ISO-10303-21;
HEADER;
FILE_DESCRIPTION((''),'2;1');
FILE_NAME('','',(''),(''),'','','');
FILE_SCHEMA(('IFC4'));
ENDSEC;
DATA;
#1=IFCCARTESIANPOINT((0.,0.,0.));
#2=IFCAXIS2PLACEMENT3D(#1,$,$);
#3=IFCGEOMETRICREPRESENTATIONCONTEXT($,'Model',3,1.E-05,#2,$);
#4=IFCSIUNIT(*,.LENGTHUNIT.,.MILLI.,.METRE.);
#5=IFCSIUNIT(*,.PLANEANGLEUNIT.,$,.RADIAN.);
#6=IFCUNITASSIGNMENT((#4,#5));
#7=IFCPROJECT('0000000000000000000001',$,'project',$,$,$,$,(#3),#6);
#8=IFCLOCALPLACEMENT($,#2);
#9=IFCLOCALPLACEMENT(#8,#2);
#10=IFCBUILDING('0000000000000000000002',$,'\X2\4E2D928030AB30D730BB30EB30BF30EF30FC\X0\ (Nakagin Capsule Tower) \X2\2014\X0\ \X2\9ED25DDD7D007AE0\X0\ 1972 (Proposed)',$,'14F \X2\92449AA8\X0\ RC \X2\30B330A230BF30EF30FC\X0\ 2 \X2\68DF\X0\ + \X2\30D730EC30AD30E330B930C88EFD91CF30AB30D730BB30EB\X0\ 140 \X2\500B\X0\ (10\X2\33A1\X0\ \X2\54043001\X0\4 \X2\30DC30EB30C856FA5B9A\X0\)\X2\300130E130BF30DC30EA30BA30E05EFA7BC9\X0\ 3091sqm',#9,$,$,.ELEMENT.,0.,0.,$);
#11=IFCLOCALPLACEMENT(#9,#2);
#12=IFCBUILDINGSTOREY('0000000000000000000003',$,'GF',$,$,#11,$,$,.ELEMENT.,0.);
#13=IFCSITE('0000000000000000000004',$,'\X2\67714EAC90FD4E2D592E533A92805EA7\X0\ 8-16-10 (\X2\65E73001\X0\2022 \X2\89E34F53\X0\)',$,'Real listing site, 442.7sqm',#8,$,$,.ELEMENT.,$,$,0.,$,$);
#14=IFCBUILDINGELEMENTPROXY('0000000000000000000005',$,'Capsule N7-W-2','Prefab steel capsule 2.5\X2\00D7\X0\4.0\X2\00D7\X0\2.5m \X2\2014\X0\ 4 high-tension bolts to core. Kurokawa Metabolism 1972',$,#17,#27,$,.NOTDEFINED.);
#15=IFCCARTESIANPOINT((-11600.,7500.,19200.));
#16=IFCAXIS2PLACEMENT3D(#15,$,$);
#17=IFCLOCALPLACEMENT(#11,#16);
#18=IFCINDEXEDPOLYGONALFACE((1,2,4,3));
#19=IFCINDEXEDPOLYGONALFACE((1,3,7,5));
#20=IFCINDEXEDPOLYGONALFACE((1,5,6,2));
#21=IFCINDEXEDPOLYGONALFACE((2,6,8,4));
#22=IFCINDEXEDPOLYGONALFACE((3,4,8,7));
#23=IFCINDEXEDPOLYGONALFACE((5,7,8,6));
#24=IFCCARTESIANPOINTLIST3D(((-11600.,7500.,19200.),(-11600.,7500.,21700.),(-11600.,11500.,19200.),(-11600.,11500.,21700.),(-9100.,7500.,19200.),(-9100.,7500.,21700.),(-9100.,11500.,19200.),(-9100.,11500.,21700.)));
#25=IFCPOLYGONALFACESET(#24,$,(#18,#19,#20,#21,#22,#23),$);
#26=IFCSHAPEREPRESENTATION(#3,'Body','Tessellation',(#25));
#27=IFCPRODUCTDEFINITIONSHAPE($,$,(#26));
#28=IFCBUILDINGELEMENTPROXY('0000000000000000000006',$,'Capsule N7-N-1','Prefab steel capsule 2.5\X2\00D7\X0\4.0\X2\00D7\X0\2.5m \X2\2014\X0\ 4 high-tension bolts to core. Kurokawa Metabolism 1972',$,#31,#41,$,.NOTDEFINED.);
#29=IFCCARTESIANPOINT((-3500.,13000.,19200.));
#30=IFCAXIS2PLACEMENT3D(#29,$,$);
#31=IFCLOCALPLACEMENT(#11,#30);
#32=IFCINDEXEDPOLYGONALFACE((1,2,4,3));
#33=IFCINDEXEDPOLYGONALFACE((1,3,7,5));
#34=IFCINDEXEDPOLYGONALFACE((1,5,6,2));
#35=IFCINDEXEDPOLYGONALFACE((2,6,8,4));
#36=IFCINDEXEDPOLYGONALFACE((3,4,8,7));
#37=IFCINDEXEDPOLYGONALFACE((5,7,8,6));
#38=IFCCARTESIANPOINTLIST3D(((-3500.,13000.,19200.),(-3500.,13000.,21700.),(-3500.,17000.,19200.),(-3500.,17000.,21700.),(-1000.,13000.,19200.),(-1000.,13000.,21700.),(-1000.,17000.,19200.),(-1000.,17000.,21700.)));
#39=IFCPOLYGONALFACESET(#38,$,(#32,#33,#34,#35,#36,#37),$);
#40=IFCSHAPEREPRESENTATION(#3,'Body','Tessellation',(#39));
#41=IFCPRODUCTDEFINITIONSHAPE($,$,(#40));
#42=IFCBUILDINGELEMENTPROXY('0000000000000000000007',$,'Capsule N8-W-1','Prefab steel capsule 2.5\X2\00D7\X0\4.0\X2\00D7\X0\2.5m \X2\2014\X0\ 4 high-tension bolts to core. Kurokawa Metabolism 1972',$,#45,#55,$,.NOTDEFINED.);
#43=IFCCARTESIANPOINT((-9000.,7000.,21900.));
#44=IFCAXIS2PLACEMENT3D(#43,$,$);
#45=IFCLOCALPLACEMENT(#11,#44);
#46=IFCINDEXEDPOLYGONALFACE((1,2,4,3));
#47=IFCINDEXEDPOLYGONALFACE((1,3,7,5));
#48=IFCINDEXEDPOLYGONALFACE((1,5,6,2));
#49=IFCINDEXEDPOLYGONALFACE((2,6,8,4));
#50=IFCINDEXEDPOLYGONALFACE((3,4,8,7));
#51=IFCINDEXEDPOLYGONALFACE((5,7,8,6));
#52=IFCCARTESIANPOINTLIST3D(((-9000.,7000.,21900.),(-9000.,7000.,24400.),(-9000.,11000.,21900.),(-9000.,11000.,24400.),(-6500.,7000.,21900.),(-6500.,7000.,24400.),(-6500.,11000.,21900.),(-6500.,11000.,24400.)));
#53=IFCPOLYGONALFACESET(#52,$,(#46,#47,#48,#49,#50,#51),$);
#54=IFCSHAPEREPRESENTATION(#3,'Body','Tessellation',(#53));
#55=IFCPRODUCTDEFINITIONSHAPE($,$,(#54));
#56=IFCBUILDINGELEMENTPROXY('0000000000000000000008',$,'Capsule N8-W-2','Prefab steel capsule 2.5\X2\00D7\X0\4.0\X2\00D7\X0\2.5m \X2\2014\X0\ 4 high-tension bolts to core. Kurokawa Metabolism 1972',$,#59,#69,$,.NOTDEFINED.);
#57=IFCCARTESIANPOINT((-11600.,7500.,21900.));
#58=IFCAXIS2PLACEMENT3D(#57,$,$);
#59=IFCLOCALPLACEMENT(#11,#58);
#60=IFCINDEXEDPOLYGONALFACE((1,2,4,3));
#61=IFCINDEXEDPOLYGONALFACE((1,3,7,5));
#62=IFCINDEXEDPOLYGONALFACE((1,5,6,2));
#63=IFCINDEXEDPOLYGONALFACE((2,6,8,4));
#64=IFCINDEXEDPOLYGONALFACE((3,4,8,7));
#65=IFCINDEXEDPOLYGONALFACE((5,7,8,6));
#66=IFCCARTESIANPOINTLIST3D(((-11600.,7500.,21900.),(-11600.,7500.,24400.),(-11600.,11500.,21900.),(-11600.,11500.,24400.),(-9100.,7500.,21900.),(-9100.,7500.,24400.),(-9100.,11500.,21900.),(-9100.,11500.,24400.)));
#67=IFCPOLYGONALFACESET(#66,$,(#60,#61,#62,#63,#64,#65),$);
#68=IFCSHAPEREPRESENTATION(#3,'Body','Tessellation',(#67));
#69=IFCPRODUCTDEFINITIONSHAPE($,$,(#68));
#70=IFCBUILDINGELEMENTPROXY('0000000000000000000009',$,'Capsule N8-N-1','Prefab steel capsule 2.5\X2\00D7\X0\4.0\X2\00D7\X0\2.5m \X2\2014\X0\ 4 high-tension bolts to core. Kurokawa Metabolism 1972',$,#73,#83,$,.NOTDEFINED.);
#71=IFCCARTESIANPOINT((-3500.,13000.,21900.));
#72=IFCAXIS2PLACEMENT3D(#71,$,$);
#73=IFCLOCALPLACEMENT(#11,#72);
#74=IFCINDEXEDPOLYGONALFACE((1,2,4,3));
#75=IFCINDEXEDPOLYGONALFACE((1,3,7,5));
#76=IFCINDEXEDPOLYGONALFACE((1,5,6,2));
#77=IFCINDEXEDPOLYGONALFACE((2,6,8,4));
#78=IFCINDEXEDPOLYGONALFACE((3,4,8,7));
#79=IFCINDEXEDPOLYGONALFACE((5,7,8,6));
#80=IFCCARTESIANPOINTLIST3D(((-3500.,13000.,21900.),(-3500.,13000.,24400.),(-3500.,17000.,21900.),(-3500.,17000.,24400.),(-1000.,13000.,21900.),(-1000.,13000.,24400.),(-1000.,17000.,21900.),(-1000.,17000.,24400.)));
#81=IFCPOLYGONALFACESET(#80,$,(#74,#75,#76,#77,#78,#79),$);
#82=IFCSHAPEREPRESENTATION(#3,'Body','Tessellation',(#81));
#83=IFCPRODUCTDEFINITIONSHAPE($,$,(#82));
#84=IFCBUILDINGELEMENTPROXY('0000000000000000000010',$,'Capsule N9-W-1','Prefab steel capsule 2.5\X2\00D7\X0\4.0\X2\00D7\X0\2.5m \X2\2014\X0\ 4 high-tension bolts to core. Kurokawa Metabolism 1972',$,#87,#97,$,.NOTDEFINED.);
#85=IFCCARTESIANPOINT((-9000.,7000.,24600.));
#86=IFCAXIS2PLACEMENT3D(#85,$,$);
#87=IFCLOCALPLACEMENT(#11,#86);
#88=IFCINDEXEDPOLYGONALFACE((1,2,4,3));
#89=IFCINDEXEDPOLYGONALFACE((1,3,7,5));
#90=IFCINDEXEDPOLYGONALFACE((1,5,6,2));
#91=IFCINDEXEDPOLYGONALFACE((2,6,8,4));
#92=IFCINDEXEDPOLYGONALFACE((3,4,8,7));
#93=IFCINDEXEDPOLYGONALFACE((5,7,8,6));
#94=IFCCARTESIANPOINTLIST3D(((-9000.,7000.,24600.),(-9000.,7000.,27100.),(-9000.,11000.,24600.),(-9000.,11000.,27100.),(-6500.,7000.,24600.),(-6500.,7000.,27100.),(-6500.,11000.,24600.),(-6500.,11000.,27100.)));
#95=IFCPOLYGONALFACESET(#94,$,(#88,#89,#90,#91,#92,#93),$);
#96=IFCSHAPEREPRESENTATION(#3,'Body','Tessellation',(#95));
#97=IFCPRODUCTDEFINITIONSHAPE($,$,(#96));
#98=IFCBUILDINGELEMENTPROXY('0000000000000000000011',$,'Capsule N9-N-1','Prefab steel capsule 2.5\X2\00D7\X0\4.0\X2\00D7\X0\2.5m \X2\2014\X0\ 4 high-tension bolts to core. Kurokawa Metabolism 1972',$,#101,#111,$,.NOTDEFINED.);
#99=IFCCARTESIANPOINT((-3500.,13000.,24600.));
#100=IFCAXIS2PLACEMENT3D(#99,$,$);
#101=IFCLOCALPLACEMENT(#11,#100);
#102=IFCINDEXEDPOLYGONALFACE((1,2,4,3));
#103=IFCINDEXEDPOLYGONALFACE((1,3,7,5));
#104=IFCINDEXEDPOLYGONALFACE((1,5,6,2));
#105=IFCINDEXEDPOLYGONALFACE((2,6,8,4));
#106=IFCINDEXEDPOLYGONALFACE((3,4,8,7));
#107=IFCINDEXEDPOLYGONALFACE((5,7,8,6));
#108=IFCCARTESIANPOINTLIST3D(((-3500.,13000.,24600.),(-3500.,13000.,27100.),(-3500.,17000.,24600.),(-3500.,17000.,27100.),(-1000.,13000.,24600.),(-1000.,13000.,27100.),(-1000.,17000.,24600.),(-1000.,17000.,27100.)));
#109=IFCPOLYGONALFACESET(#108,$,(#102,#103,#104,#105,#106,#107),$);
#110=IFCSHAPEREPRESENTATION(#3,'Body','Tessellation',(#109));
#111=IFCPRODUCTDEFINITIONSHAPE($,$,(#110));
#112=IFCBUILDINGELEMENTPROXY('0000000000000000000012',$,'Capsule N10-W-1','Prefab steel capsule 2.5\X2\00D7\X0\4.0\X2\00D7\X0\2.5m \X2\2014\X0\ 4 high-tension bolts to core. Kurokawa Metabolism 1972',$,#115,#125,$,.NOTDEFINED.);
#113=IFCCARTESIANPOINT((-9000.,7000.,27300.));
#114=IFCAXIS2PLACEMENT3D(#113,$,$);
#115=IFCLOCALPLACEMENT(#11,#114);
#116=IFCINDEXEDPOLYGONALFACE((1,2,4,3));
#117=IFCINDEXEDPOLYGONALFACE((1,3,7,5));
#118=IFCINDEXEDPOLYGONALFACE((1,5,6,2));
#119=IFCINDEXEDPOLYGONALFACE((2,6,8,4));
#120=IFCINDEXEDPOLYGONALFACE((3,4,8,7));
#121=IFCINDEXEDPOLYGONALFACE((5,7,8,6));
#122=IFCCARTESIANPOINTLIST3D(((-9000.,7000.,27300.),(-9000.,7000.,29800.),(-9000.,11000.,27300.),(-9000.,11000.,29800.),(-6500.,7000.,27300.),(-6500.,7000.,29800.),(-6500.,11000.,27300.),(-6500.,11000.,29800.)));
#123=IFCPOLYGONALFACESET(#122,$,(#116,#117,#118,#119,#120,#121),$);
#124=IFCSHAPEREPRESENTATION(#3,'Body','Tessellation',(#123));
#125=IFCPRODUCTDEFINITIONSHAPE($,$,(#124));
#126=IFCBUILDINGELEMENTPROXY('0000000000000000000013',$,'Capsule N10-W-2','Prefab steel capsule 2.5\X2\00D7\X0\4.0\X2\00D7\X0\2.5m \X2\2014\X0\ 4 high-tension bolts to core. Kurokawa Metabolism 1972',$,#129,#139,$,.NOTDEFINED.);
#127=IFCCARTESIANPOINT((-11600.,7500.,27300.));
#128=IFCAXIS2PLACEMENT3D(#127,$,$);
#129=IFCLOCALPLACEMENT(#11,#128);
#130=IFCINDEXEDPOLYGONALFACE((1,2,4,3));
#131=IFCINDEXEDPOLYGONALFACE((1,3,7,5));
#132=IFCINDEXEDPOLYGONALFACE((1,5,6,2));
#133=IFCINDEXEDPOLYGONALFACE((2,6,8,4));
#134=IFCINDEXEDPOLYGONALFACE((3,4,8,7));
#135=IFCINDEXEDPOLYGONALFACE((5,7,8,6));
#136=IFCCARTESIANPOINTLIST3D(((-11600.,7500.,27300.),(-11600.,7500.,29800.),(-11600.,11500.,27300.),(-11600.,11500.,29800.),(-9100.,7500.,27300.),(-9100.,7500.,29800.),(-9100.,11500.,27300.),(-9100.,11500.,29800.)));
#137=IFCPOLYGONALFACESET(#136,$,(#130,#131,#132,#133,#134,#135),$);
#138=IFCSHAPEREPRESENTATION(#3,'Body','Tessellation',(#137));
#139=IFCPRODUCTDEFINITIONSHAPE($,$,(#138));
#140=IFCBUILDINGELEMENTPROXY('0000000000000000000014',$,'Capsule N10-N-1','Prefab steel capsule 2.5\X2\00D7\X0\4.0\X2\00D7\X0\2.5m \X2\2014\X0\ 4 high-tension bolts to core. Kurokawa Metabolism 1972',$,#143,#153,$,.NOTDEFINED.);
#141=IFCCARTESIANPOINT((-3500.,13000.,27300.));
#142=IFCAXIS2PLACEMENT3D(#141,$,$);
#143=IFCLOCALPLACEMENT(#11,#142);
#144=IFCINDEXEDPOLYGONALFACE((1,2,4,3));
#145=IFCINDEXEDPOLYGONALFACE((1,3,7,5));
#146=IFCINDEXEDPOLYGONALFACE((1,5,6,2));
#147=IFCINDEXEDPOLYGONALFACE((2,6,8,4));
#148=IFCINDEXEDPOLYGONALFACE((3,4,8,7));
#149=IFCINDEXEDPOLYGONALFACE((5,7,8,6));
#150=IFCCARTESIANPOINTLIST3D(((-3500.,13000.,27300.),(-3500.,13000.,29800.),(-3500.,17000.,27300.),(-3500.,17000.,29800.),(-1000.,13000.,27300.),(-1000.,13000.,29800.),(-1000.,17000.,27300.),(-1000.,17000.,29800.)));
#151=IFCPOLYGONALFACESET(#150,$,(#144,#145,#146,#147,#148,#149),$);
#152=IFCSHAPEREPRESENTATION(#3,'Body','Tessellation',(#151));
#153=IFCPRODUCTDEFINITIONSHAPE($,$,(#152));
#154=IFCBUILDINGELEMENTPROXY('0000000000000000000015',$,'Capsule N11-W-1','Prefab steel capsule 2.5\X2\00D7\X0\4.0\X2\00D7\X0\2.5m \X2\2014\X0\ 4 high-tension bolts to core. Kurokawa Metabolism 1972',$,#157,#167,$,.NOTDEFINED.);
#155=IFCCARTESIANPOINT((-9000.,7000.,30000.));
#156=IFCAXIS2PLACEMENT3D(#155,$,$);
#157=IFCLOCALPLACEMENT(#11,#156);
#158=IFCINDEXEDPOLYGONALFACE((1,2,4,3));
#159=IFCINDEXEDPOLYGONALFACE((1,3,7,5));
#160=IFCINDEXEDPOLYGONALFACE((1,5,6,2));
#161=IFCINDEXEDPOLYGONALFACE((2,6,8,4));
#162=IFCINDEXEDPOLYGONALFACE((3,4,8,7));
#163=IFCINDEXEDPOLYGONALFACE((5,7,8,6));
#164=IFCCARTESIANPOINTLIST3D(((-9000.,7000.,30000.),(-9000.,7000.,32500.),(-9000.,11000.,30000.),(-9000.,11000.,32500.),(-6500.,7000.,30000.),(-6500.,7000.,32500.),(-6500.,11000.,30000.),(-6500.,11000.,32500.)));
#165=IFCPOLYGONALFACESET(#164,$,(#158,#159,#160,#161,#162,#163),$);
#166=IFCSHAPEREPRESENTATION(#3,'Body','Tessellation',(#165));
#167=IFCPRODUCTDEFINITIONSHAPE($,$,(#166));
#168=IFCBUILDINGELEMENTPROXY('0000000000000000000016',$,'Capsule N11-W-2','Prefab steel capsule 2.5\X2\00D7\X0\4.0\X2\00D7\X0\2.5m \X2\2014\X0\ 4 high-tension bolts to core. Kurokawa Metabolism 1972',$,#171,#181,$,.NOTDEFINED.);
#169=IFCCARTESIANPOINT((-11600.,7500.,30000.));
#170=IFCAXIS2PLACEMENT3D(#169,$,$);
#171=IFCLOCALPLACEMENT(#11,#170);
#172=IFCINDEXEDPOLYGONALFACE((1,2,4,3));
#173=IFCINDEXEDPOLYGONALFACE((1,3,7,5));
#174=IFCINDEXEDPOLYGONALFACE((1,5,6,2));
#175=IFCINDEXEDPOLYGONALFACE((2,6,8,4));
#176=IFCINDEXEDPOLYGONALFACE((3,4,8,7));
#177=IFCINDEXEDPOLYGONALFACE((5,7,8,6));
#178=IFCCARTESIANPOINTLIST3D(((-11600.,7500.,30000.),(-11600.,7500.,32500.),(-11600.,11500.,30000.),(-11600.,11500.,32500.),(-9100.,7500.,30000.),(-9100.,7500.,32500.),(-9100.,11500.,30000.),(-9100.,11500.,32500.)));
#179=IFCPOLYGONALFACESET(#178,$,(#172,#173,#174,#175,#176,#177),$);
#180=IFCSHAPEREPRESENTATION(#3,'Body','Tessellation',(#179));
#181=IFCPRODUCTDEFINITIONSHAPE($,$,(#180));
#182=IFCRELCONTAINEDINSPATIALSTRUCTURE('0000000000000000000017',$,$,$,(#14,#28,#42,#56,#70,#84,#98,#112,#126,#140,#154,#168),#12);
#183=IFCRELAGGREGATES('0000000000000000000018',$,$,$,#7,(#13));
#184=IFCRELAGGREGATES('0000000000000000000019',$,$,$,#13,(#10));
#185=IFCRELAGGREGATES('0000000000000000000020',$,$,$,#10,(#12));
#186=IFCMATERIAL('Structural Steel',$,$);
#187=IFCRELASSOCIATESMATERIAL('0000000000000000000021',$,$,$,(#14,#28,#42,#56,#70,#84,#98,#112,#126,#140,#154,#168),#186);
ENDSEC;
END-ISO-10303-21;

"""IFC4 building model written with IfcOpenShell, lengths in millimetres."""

from ifc_helpers import new_model, si_unit, frame, frame_2d, origin, place, context, project, spatial, rectangle, extrude, material, element, save


model = new_model("IFC4")

# Units and contexts
model_context = context("Model", 3, precision=1e-05, world=origin())
ifc_project = project(units=[si_unit("LENGTHUNIT", "METRE", prefix="MILLI"), si_unit("PLANEANGLEUNIT", "RADIAN")], contexts=[model_context])

# Site, building, storey
site_placement = place(None, origin())
site = spatial("IfcSite", under=ifc_project, at=site_placement, Name="東京都中央区銀座 8-16-10 (旧、2022 解体)", ObjectType="Real listing site, 442.7sqm", CompositionType="ELEMENT", RefElevation=0.0)
building_placement = place(site_placement, origin())
building = spatial("IfcBuilding", under=site, at=building_placement, Name="中銀カプセルタワー (Nakagin Capsule Tower) — 黒川紀章 1972 (Proposed)", ObjectType="14F 鉄骨 RC コアタワー 2 棟 + プレキャスト軽量カプセル 140 個 (10㎡ 各、4 ボルト固定)、メタボリズム建築 3091sqm", CompositionType="ELEMENT", ElevationOfRefHeight=0.0, ElevationOfTerrain=0.0)
storey_placement = place(building_placement, origin())
storey = spatial("IfcBuildingStorey", under=building, at=storey_placement, Name="GF", CompositionType="ELEMENT", Elevation=0.0)

# Shared definitions
ifc_material_1 = material(Name="Structural Steel")

# Building element proxies
proxy_1_placement = place(storey_placement, frame((-11600.0, 7500.0, 19200.0)))
element("IfcBuildingElementProxy", 1, at=proxy_1_placement, inside=storey, material=ifc_material_1, Name="Capsule N7-W-2", Description="Prefab steel capsule 2.5×4.0×2.5m — 4 high-tension bolts to core. Kurokawa Metabolism 1972", PredefinedType="NOTDEFINED", context=model_context, shape_type="SweptSolid", body=[
    extrude(rectangle(XDim=2500.0, YDim=4000.0, at=frame_2d((1250.0, 2000.0))), frame((-11600.0, 7500.0, 19200.0)), (0.0, 0.0, 1.0), 2500.0),
])
proxy_2_placement = place(storey_placement, frame((-3500.0, 13000.0, 19200.0)))
element("IfcBuildingElementProxy", 2, at=proxy_2_placement, inside=storey, material=ifc_material_1, Name="Capsule N7-N-1", Description="Prefab steel capsule 2.5×4.0×2.5m — 4 high-tension bolts to core. Kurokawa Metabolism 1972", PredefinedType="NOTDEFINED", context=model_context, shape_type="SweptSolid", body=[
    extrude(rectangle(XDim=2500.0, YDim=4000.0, at=frame_2d((1250.0, 2000.0))), frame((-3500.0, 13000.0, 19200.0)), (0.0, 0.0, 1.0), 2500.0),
])
proxy_3_placement = place(storey_placement, frame((-9000.0, 7000.0, 21900.0)))
element("IfcBuildingElementProxy", 3, at=proxy_3_placement, inside=storey, material=ifc_material_1, Name="Capsule N8-W-1", Description="Prefab steel capsule 2.5×4.0×2.5m — 4 high-tension bolts to core. Kurokawa Metabolism 1972", PredefinedType="NOTDEFINED", context=model_context, shape_type="SweptSolid", body=[
    extrude(rectangle(XDim=2500.0, YDim=4000.0, at=frame_2d((1250.0, 2000.0))), frame((-9000.0, 7000.0, 21900.0)), (0.0, 0.0, 1.0), 2500.0),
])
proxy_4_placement = place(storey_placement, frame((-11600.0, 7500.0, 21900.0)))
element("IfcBuildingElementProxy", 4, at=proxy_4_placement, inside=storey, material=ifc_material_1, Name="Capsule N8-W-2", Description="Prefab steel capsule 2.5×4.0×2.5m — 4 high-tension bolts to core. Kurokawa Metabolism 1972", PredefinedType="NOTDEFINED", context=model_context, shape_type="SweptSolid", body=[
    extrude(rectangle(XDim=2500.0, YDim=4000.0, at=frame_2d((1250.0, 2000.0))), frame((-11600.0, 7500.0, 21900.0)), (0.0, 0.0, 1.0), 2500.0),
])
proxy_5_placement = place(storey_placement, frame((-3500.0, 13000.0, 21900.0)))
element("IfcBuildingElementProxy", 5, at=proxy_5_placement, inside=storey, material=ifc_material_1, Name="Capsule N8-N-1", Description="Prefab steel capsule 2.5×4.0×2.5m — 4 high-tension bolts to core. Kurokawa Metabolism 1972", PredefinedType="NOTDEFINED", context=model_context, shape_type="SweptSolid", body=[
    extrude(rectangle(XDim=2500.0, YDim=4000.0, at=frame_2d((1250.0, 2000.0))), frame((-3500.0, 13000.0, 21900.0)), (0.0, 0.0, 1.0), 2500.0),
])
proxy_6_placement = place(storey_placement, frame((-9000.0, 7000.0, 24600.0)))
element("IfcBuildingElementProxy", 6, at=proxy_6_placement, inside=storey, material=ifc_material_1, Name="Capsule N9-W-1", Description="Prefab steel capsule 2.5×4.0×2.5m — 4 high-tension bolts to core. Kurokawa Metabolism 1972", PredefinedType="NOTDEFINED", context=model_context, shape_type="SweptSolid", body=[
    extrude(rectangle(XDim=2500.0, YDim=4000.0, at=frame_2d((1250.0, 2000.0))), frame((-9000.0, 7000.0, 24600.0)), (0.0, 0.0, 1.0), 2500.0),
])
proxy_7_placement = place(storey_placement, frame((-3500.0, 13000.0, 24600.0)))
element("IfcBuildingElementProxy", 7, at=proxy_7_placement, inside=storey, material=ifc_material_1, Name="Capsule N9-N-1", Description="Prefab steel capsule 2.5×4.0×2.5m — 4 high-tension bolts to core. Kurokawa Metabolism 1972", PredefinedType="NOTDEFINED", context=model_context, shape_type="SweptSolid", body=[
    extrude(rectangle(XDim=2500.0, YDim=4000.0, at=frame_2d((1250.0, 2000.0))), frame((-3500.0, 13000.0, 24600.0)), (0.0, 0.0, 1.0), 2500.0),
])
proxy_8_placement = place(storey_placement, frame((-9000.0, 7000.0, 27300.0)))
element("IfcBuildingElementProxy", 8, at=proxy_8_placement, inside=storey, material=ifc_material_1, Name="Capsule N10-W-1", Description="Prefab steel capsule 2.5×4.0×2.5m — 4 high-tension bolts to core. Kurokawa Metabolism 1972", PredefinedType="NOTDEFINED", context=model_context, shape_type="SweptSolid", body=[
    extrude(rectangle(XDim=2500.0, YDim=4000.0, at=frame_2d((1250.0, 2000.0))), frame((-9000.0, 7000.0, 27300.0)), (0.0, 0.0, 1.0), 2500.0),
])
proxy_9_placement = place(storey_placement, frame((-11600.0, 7500.0, 27300.0)))
element("IfcBuildingElementProxy", 9, at=proxy_9_placement, inside=storey, material=ifc_material_1, Name="Capsule N10-W-2", Description="Prefab steel capsule 2.5×4.0×2.5m — 4 high-tension bolts to core. Kurokawa Metabolism 1972", PredefinedType="NOTDEFINED", context=model_context, shape_type="SweptSolid", body=[
    extrude(rectangle(XDim=2500.0, YDim=4000.0, at=frame_2d((1250.0, 2000.0))), frame((-11600.0, 7500.0, 27300.0)), (0.0, 0.0, 1.0), 2500.0),
])
proxy_10_placement = place(storey_placement, frame((-3500.0, 13000.0, 27300.0)))
element("IfcBuildingElementProxy", 10, at=proxy_10_placement, inside=storey, material=ifc_material_1, Name="Capsule N10-N-1", Description="Prefab steel capsule 2.5×4.0×2.5m — 4 high-tension bolts to core. Kurokawa Metabolism 1972", PredefinedType="NOTDEFINED", context=model_context, shape_type="SweptSolid", body=[
    extrude(rectangle(XDim=2500.0, YDim=4000.0, at=frame_2d((1250.0, 2000.0))), frame((-3500.0, 13000.0, 27300.0)), (0.0, 0.0, 1.0), 2500.0),
])
proxy_11_placement = place(storey_placement, frame((-9000.0, 7000.0, 30000.0)))
element("IfcBuildingElementProxy", 11, at=proxy_11_placement, inside=storey, material=ifc_material_1, Name="Capsule N11-W-1", Description="Prefab steel capsule 2.5×4.0×2.5m — 4 high-tension bolts to core. Kurokawa Metabolism 1972", PredefinedType="NOTDEFINED", context=model_context, shape_type="SweptSolid", body=[
    extrude(rectangle(XDim=2500.0, YDim=4000.0, at=frame_2d((1250.0, 2000.0))), frame((-9000.0, 7000.0, 30000.0)), (0.0, 0.0, 1.0), 2500.0),
])
proxy_12_placement = place(storey_placement, frame((-11600.0, 7500.0, 30000.0)))
element("IfcBuildingElementProxy", 12, at=proxy_12_placement, inside=storey, material=ifc_material_1, Name="Capsule N11-W-2", Description="Prefab steel capsule 2.5×4.0×2.5m — 4 high-tension bolts to core. Kurokawa Metabolism 1972", PredefinedType="NOTDEFINED", context=model_context, shape_type="SweptSolid", body=[
    extrude(rectangle(XDim=2500.0, YDim=4000.0, at=frame_2d((1250.0, 2000.0))), frame((-11600.0, 7500.0, 30000.0)), (0.0, 0.0, 1.0), 2500.0),
])

save(model, "model.ifc")
